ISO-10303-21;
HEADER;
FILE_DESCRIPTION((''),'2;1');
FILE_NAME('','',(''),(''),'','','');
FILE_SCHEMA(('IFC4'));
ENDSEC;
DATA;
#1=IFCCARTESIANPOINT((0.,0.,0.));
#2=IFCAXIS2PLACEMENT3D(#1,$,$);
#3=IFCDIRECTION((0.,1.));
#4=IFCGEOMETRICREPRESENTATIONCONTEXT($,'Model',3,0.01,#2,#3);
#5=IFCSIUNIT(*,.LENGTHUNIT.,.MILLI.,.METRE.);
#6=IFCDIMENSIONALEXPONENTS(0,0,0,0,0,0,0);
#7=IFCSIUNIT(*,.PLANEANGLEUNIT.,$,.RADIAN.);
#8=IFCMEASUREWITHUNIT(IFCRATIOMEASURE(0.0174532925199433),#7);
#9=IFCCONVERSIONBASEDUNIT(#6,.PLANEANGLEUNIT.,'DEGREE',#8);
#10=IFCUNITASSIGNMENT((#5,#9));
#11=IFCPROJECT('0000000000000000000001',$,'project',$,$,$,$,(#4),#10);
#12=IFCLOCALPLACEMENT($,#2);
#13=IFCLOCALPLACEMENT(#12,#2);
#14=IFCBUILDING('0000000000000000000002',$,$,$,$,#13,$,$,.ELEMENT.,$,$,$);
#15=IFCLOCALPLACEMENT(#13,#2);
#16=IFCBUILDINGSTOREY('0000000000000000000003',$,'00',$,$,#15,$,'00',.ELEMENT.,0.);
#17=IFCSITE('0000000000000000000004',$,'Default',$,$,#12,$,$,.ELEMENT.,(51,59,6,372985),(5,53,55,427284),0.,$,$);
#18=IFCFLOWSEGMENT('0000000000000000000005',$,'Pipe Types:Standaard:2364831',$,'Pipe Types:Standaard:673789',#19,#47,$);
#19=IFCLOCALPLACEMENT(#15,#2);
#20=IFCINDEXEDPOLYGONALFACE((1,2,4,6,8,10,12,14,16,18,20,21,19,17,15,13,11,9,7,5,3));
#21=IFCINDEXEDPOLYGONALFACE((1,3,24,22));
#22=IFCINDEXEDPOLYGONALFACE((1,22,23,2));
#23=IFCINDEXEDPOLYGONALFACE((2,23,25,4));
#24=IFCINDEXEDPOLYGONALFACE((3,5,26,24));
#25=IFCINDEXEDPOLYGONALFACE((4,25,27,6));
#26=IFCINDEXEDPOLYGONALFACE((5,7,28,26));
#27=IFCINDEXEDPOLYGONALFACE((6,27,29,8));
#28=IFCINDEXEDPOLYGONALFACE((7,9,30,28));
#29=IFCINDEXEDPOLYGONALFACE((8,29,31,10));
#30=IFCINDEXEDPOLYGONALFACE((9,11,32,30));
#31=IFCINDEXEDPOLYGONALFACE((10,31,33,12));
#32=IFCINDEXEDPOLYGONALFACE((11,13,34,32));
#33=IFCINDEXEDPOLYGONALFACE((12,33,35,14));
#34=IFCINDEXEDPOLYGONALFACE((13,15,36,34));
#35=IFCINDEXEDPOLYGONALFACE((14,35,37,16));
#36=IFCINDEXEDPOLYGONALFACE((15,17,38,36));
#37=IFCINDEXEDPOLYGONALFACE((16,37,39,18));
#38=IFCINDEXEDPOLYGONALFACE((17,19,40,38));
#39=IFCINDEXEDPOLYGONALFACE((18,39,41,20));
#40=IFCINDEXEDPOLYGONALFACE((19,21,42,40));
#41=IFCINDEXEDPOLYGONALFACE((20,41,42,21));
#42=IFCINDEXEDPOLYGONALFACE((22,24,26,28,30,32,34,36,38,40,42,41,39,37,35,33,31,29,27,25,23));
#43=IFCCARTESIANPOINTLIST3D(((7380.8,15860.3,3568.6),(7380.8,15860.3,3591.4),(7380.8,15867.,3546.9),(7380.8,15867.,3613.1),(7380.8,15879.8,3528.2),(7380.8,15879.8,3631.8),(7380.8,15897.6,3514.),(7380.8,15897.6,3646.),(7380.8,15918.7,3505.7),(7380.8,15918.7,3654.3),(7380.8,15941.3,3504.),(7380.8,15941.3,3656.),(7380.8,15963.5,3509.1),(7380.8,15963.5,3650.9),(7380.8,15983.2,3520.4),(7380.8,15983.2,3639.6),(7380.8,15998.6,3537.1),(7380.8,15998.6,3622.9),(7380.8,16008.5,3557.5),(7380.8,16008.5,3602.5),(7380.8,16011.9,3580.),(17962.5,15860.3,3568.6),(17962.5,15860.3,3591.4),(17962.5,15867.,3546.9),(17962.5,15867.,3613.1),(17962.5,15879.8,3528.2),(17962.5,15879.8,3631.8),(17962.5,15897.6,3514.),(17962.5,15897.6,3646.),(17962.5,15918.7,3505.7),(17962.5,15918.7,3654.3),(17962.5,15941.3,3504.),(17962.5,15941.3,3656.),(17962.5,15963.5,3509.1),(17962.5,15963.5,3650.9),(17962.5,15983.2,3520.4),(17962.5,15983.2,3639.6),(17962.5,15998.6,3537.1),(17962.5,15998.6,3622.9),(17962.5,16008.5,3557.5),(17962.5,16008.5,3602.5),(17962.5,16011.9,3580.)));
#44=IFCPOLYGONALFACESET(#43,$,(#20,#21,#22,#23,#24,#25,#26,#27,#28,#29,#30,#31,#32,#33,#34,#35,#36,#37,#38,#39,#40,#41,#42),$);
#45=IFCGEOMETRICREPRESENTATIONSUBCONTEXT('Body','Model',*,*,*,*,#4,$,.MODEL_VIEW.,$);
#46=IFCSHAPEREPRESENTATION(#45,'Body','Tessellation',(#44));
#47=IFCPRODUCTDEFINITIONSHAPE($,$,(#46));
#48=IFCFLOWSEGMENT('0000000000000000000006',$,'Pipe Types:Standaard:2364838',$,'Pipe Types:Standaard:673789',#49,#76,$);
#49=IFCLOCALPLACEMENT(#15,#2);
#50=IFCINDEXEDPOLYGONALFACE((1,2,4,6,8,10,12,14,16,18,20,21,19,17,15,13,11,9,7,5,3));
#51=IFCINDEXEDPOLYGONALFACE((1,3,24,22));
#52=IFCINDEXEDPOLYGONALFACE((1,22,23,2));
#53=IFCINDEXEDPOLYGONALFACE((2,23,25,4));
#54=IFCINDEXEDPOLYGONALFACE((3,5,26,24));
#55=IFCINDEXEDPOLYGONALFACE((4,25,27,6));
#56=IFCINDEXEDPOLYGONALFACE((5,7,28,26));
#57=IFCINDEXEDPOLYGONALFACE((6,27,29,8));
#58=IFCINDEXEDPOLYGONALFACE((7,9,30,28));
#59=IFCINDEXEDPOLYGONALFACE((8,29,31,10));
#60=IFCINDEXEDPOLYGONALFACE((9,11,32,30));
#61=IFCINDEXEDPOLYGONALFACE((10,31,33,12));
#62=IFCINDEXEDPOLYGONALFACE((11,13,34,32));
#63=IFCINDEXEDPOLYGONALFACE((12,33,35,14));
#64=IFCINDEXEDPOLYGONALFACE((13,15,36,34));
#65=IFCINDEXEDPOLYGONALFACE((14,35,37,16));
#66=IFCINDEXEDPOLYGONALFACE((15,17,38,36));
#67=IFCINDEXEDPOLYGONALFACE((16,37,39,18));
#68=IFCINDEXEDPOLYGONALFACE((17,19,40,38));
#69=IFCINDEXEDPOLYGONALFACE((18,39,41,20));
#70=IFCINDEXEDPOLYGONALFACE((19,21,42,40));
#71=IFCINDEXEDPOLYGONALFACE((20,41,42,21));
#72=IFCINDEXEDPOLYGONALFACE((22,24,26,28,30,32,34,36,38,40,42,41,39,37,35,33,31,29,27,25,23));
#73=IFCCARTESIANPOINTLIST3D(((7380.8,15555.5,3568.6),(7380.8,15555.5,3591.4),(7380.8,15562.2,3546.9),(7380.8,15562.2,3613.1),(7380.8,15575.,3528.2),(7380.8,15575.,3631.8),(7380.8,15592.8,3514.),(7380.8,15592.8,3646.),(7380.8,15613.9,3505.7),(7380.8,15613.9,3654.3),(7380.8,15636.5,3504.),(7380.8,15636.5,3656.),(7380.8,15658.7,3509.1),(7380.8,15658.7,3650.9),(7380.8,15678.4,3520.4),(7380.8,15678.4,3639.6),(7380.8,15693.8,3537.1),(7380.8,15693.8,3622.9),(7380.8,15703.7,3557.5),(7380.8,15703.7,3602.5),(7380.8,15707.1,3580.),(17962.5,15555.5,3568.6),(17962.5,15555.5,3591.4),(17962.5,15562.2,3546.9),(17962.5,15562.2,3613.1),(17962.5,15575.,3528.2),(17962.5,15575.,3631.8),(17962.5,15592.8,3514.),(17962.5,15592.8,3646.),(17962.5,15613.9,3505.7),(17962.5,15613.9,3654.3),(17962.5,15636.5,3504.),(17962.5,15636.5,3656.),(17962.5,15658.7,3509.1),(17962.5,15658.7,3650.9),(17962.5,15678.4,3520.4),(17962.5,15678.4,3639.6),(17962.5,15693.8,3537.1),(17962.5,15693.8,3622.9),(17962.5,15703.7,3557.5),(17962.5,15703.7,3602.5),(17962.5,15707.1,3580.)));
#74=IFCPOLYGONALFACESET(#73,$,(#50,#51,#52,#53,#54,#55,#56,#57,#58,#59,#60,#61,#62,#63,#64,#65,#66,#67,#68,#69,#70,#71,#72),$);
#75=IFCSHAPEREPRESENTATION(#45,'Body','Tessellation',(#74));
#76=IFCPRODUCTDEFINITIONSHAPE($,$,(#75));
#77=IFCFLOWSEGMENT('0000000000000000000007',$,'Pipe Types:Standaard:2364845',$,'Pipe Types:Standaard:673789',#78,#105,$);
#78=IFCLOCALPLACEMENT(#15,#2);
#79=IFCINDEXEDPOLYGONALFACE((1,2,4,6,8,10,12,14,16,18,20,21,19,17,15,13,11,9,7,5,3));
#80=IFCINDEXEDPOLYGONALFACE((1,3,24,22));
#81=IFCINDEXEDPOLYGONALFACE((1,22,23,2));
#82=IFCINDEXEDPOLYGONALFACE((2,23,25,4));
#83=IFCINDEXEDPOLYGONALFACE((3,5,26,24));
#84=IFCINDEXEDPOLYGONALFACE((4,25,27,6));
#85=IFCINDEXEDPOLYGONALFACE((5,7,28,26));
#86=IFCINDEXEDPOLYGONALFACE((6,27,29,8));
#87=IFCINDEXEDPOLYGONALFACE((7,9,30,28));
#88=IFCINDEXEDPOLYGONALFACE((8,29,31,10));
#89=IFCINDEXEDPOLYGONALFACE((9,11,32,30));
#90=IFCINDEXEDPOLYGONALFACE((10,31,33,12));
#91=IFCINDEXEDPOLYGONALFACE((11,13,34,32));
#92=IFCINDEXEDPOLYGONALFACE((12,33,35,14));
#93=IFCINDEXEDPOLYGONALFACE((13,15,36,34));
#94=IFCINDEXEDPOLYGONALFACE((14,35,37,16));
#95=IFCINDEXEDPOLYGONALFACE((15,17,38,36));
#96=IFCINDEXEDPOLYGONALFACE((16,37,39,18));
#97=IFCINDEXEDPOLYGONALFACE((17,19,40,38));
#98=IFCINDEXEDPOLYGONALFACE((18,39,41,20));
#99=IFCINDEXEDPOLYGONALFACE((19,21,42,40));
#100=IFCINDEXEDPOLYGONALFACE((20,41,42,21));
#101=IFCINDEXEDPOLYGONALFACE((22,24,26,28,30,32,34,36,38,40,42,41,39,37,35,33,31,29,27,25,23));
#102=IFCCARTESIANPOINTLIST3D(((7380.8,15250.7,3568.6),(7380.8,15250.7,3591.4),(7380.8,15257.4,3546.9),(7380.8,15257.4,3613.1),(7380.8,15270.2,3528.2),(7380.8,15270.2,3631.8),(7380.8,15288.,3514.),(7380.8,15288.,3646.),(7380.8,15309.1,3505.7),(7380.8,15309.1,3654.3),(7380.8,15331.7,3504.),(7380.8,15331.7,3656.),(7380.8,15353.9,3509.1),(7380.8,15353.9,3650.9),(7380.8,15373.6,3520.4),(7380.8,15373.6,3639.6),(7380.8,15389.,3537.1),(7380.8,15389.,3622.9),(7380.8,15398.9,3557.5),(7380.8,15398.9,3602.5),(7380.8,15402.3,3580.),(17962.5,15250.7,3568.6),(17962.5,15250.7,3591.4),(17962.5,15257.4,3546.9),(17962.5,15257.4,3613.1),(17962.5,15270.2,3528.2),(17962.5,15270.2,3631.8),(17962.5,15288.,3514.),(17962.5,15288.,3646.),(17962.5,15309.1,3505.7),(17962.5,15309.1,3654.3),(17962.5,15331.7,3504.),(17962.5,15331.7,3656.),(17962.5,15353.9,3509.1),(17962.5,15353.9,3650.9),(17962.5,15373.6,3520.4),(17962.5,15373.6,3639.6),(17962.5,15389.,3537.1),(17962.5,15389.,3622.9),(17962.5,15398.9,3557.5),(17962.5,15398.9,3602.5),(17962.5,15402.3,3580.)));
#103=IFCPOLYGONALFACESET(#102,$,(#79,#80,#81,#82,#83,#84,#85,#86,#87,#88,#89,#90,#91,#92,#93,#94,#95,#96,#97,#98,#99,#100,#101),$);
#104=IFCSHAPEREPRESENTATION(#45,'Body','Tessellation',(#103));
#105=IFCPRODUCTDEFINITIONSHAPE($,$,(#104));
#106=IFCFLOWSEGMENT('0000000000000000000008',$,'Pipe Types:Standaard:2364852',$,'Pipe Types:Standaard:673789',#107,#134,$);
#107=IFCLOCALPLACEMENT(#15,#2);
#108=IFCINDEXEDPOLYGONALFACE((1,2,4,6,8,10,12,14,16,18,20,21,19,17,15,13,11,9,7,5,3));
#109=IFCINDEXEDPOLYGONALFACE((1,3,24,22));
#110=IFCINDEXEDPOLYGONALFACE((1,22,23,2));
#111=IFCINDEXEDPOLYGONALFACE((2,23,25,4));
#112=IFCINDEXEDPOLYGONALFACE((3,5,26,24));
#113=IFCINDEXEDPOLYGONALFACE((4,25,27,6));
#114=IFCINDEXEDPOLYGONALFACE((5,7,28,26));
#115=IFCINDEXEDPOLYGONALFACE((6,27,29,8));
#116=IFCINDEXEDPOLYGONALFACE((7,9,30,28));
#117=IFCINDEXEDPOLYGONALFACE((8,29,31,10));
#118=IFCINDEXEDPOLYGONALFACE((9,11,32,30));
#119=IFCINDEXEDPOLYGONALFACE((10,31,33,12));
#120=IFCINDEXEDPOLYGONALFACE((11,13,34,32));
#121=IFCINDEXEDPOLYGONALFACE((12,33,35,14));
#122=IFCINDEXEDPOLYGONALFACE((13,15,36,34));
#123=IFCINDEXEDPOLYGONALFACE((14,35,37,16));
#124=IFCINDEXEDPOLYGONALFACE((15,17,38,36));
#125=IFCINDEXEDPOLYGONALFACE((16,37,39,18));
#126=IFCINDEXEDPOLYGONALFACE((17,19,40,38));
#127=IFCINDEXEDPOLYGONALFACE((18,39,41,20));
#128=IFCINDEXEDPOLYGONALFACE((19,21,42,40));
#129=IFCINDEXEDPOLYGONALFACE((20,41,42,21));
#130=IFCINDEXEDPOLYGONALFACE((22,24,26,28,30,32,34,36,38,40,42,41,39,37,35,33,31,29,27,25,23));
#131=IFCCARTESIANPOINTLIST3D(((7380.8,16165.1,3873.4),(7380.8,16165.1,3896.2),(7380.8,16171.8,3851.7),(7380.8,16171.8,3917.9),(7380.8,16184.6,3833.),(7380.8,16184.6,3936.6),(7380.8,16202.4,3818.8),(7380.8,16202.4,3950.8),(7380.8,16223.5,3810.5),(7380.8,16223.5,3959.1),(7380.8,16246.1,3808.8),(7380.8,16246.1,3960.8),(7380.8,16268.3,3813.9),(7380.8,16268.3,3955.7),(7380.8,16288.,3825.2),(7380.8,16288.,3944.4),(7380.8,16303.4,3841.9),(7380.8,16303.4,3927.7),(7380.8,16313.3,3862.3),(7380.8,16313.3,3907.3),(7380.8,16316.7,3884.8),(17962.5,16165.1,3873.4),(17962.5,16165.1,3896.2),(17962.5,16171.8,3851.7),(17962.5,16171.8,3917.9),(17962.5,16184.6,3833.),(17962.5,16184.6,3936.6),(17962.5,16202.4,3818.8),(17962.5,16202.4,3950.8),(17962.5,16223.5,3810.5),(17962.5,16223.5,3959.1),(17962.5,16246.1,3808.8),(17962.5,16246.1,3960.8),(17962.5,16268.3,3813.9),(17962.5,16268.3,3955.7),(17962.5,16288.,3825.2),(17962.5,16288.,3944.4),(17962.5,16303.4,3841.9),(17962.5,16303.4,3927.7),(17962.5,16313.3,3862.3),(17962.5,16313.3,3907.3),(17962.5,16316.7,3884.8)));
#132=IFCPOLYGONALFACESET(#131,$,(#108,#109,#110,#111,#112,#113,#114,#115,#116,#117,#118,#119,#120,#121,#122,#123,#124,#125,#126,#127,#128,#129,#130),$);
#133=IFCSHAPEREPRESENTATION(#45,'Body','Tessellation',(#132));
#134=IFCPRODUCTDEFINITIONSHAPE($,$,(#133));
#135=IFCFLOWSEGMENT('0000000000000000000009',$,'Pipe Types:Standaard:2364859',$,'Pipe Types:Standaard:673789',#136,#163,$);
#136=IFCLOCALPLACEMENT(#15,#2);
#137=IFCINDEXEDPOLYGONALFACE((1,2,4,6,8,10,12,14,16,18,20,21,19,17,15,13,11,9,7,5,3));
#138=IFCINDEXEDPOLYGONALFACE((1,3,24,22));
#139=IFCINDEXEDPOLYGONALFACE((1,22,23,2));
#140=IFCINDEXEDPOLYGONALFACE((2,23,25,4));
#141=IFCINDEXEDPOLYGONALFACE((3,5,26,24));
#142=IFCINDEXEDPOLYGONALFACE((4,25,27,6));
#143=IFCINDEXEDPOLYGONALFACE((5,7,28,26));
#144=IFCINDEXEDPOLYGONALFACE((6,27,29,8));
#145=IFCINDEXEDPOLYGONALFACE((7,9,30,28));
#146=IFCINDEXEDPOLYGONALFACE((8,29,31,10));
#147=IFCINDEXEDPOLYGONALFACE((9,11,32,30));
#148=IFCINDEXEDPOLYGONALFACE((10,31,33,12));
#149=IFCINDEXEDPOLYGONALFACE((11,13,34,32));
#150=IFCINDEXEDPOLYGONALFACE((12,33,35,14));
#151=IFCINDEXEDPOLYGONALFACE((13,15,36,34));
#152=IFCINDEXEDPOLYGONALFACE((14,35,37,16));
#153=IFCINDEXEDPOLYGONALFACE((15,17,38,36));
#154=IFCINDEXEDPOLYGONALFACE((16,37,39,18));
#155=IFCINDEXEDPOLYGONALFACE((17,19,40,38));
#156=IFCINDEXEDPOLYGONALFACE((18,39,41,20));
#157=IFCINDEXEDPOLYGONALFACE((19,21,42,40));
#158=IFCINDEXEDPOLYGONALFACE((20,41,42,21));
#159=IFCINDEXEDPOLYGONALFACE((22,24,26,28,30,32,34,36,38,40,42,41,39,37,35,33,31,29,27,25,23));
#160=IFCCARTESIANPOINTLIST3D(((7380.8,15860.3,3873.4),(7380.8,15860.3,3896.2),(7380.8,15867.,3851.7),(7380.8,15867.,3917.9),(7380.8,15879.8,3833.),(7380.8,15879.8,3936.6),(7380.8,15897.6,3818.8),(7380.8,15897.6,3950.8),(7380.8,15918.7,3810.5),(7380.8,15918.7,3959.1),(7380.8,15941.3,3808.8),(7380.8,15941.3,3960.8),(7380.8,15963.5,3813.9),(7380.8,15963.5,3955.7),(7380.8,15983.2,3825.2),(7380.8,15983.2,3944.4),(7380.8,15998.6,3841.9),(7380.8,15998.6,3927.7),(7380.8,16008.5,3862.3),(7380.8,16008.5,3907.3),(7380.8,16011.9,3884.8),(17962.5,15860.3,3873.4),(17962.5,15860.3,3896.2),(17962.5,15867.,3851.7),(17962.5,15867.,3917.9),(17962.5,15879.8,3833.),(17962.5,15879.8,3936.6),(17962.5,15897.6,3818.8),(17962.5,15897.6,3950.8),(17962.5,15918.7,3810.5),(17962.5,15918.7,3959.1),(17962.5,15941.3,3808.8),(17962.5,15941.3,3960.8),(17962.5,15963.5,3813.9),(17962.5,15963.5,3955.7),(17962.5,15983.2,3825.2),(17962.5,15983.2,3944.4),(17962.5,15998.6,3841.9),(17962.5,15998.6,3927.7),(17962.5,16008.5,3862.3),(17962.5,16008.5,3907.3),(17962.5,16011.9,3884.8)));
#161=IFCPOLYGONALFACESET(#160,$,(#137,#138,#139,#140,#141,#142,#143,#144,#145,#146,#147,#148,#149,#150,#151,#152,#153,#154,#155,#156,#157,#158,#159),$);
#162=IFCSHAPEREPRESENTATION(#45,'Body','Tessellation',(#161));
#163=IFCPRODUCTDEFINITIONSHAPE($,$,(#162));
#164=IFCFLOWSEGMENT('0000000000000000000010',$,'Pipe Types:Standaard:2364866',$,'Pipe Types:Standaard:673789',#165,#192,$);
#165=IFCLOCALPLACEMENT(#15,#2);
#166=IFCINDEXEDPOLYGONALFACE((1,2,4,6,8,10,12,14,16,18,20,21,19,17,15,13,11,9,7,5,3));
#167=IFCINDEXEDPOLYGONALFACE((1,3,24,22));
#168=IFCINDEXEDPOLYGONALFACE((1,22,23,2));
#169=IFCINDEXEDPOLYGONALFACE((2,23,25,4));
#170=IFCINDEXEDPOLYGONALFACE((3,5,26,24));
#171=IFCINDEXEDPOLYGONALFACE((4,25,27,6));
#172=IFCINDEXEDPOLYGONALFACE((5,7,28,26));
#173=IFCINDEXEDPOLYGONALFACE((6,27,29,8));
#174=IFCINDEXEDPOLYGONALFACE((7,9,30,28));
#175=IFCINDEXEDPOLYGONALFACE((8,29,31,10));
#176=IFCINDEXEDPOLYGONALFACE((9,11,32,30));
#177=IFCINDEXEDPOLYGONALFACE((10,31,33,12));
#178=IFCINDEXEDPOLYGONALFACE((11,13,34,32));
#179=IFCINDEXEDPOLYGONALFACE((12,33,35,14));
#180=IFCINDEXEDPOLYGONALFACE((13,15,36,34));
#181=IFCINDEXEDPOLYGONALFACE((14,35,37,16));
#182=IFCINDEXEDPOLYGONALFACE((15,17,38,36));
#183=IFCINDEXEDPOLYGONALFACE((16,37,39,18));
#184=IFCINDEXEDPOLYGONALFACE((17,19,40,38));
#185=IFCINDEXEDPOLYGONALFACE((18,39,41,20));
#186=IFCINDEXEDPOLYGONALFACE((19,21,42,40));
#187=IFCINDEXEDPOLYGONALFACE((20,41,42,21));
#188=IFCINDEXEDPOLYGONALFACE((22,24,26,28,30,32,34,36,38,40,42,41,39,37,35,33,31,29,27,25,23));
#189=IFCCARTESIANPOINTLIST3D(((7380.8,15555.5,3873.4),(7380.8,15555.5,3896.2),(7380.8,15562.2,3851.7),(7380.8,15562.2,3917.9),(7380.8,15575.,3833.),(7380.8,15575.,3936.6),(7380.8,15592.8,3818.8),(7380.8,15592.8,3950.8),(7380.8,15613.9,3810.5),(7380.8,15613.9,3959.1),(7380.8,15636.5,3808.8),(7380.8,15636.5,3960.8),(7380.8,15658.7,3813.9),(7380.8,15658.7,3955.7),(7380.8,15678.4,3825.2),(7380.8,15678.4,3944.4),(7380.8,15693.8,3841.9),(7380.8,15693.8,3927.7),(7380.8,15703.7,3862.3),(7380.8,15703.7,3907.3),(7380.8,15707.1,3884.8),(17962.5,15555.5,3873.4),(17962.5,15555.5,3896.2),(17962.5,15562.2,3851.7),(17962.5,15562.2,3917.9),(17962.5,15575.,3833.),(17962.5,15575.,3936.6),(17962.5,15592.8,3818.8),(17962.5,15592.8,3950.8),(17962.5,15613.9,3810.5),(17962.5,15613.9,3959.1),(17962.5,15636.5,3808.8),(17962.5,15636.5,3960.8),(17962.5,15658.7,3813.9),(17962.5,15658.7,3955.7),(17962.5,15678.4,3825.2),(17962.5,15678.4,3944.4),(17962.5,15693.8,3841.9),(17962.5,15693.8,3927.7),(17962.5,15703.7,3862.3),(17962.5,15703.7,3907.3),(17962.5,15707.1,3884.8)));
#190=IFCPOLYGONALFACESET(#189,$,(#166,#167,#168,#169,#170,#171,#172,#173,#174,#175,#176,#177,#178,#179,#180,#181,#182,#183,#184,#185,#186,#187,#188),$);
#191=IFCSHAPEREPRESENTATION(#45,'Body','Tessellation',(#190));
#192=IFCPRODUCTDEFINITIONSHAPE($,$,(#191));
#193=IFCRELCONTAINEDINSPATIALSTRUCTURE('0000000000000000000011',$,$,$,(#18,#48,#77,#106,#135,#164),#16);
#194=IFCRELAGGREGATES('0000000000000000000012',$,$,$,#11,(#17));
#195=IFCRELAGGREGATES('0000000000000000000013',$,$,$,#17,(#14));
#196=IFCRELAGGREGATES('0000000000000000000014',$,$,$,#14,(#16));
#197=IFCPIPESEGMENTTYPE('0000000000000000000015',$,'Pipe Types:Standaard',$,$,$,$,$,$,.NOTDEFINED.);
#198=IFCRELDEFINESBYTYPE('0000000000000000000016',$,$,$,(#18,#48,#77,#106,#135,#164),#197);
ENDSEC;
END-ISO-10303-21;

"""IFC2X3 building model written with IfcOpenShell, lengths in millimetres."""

from ifc_helpers import new_model, entity, si_unit, converted_unit, direction, frame, frame_2d, origin, place, context, subcontext, project, spatial, circle, extrude, type_object, element, save


model = new_model("IFC2X3")

# Units and contexts
model_context = context("Model", 3, precision=0.01, world=origin(), true_north=direction((0.0, 1.0)))
body_context = subcontext(model_context, "Body", "Model", "MODEL_VIEW")
ifc_project = project(units=[si_unit("LENGTHUNIT", "METRE", prefix="MILLI"), converted_unit("PLANEANGLEUNIT", "DEGREE", entity("IfcRatioMeasure", 0.0174532925199433), si_unit("PLANEANGLEUNIT", "RADIAN"), dimensions=[0, 0, 0, 0, 0, 0, 0])], contexts=[model_context])

# Site, building, storey
site_placement = place(None, origin())
site = spatial("IfcSite", under=ifc_project, at=site_placement, Name="Default", CompositionType="ELEMENT", RefLatitude=(51, 59, 6, 372985), RefLongitude=(5, 53, 55, 427284), RefElevation=0.0)
building_placement = place(site_placement, origin())
building = spatial("IfcBuilding", under=site, at=building_placement, CompositionType="ELEMENT")
storey_placement = place(building_placement, origin())
storey = spatial("IfcBuildingStorey", under=building, at=storey_placement, Name="00", LongName="00", CompositionType="ELEMENT", Elevation=0.0)

# Flow segments
pipe_segment_type = type_object("IfcPipeSegmentType", Name="Pipe Types:Standaard", PredefinedType="NOTDEFINED")
flow_segment_1_placement = place(storey_placement, origin())
element("IfcFlowSegment", 1, at=flow_segment_1_placement, inside=storey, type_object=pipe_segment_type, Name="Pipe Types:Standaard:2364831", ObjectType="Pipe Types:Standaard:673789", context=body_context, shape_type="SweptSolid", body=[
    extrude(circle(Radius=76.2, at=frame_2d((0.0, 0.0), x_axis=(1.0, 0.0))), frame((7380.8, 15935.7, 3580.0), z_axis=(1.0, 0.0, 0.0), x_axis=(0.0, 1.0, 0.0)), (0.0, 0.0, 1.0), 10581.7),
])
flow_segment_2_placement = place(storey_placement, origin())
element("IfcFlowSegment", 2, at=flow_segment_2_placement, inside=storey, type_object=pipe_segment_type, Name="Pipe Types:Standaard:2364838", ObjectType="Pipe Types:Standaard:673789", context=body_context, shape_type="SweptSolid", body=[
    extrude(circle(Radius=76.2, at=frame_2d((0.0, 0.0), x_axis=(1.0, 0.0))), frame((7380.8, 15630.9, 3580.0), z_axis=(1.0, 0.0, 0.0), x_axis=(0.0, 1.0, 0.0)), (0.0, 0.0, 1.0), 10581.7),
])
flow_segment_3_placement = place(storey_placement, origin())
element("IfcFlowSegment", 3, at=flow_segment_3_placement, inside=storey, type_object=pipe_segment_type, Name="Pipe Types:Standaard:2364845", ObjectType="Pipe Types:Standaard:673789", context=body_context, shape_type="SweptSolid", body=[
    extrude(circle(Radius=76.2, at=frame_2d((0.0, 0.0), x_axis=(1.0, 0.0))), frame((7380.8, 15326.1, 3580.0), z_axis=(1.0, 0.0, 0.0), x_axis=(0.0, 1.0, 0.0)), (0.0, 0.0, 1.0), 10581.7),
])
flow_segment_4_placement = place(storey_placement, origin())
element("IfcFlowSegment", 4, at=flow_segment_4_placement, inside=storey, type_object=pipe_segment_type, Name="Pipe Types:Standaard:2364852", ObjectType="Pipe Types:Standaard:673789", context=body_context, shape_type="SweptSolid", body=[
    extrude(circle(Radius=76.2, at=frame_2d((0.0, 0.0), x_axis=(1.0, 0.0))), frame((7380.8, 16240.5, 3884.8), z_axis=(1.0, 0.0, 0.0), x_axis=(0.0, 1.0, 0.0)), (0.0, 0.0, 1.0), 10581.7),
])
flow_segment_5_placement = place(storey_placement, origin())
element("IfcFlowSegment", 5, at=flow_segment_5_placement, inside=storey, type_object=pipe_segment_type, Name="Pipe Types:Standaard:2364859", ObjectType="Pipe Types:Standaard:673789", context=body_context, shape_type="SweptSolid", body=[
    extrude(circle(Radius=76.2, at=frame_2d((0.0, 0.0), x_axis=(1.0, 0.0))), frame((7380.8, 15935.7, 3884.8), z_axis=(1.0, 0.0, 0.0), x_axis=(0.0, 1.0, 0.0)), (0.0, 0.0, 1.0), 10581.7),
])
flow_segment_6_placement = place(storey_placement, origin())
element("IfcFlowSegment", 6, at=flow_segment_6_placement, inside=storey, type_object=pipe_segment_type, Name="Pipe Types:Standaard:2364866", ObjectType="Pipe Types:Standaard:673789", context=body_context, shape_type="SweptSolid", body=[
    extrude(circle(Radius=76.2, at=frame_2d((0.0, 0.0), x_axis=(1.0, 0.0))), frame((7380.8, 15630.9, 3884.8), z_axis=(1.0, 0.0, 0.0), x_axis=(0.0, 1.0, 0.0)), (0.0, 0.0, 1.0), 10581.7),
])

save(model, "model.ifc")
